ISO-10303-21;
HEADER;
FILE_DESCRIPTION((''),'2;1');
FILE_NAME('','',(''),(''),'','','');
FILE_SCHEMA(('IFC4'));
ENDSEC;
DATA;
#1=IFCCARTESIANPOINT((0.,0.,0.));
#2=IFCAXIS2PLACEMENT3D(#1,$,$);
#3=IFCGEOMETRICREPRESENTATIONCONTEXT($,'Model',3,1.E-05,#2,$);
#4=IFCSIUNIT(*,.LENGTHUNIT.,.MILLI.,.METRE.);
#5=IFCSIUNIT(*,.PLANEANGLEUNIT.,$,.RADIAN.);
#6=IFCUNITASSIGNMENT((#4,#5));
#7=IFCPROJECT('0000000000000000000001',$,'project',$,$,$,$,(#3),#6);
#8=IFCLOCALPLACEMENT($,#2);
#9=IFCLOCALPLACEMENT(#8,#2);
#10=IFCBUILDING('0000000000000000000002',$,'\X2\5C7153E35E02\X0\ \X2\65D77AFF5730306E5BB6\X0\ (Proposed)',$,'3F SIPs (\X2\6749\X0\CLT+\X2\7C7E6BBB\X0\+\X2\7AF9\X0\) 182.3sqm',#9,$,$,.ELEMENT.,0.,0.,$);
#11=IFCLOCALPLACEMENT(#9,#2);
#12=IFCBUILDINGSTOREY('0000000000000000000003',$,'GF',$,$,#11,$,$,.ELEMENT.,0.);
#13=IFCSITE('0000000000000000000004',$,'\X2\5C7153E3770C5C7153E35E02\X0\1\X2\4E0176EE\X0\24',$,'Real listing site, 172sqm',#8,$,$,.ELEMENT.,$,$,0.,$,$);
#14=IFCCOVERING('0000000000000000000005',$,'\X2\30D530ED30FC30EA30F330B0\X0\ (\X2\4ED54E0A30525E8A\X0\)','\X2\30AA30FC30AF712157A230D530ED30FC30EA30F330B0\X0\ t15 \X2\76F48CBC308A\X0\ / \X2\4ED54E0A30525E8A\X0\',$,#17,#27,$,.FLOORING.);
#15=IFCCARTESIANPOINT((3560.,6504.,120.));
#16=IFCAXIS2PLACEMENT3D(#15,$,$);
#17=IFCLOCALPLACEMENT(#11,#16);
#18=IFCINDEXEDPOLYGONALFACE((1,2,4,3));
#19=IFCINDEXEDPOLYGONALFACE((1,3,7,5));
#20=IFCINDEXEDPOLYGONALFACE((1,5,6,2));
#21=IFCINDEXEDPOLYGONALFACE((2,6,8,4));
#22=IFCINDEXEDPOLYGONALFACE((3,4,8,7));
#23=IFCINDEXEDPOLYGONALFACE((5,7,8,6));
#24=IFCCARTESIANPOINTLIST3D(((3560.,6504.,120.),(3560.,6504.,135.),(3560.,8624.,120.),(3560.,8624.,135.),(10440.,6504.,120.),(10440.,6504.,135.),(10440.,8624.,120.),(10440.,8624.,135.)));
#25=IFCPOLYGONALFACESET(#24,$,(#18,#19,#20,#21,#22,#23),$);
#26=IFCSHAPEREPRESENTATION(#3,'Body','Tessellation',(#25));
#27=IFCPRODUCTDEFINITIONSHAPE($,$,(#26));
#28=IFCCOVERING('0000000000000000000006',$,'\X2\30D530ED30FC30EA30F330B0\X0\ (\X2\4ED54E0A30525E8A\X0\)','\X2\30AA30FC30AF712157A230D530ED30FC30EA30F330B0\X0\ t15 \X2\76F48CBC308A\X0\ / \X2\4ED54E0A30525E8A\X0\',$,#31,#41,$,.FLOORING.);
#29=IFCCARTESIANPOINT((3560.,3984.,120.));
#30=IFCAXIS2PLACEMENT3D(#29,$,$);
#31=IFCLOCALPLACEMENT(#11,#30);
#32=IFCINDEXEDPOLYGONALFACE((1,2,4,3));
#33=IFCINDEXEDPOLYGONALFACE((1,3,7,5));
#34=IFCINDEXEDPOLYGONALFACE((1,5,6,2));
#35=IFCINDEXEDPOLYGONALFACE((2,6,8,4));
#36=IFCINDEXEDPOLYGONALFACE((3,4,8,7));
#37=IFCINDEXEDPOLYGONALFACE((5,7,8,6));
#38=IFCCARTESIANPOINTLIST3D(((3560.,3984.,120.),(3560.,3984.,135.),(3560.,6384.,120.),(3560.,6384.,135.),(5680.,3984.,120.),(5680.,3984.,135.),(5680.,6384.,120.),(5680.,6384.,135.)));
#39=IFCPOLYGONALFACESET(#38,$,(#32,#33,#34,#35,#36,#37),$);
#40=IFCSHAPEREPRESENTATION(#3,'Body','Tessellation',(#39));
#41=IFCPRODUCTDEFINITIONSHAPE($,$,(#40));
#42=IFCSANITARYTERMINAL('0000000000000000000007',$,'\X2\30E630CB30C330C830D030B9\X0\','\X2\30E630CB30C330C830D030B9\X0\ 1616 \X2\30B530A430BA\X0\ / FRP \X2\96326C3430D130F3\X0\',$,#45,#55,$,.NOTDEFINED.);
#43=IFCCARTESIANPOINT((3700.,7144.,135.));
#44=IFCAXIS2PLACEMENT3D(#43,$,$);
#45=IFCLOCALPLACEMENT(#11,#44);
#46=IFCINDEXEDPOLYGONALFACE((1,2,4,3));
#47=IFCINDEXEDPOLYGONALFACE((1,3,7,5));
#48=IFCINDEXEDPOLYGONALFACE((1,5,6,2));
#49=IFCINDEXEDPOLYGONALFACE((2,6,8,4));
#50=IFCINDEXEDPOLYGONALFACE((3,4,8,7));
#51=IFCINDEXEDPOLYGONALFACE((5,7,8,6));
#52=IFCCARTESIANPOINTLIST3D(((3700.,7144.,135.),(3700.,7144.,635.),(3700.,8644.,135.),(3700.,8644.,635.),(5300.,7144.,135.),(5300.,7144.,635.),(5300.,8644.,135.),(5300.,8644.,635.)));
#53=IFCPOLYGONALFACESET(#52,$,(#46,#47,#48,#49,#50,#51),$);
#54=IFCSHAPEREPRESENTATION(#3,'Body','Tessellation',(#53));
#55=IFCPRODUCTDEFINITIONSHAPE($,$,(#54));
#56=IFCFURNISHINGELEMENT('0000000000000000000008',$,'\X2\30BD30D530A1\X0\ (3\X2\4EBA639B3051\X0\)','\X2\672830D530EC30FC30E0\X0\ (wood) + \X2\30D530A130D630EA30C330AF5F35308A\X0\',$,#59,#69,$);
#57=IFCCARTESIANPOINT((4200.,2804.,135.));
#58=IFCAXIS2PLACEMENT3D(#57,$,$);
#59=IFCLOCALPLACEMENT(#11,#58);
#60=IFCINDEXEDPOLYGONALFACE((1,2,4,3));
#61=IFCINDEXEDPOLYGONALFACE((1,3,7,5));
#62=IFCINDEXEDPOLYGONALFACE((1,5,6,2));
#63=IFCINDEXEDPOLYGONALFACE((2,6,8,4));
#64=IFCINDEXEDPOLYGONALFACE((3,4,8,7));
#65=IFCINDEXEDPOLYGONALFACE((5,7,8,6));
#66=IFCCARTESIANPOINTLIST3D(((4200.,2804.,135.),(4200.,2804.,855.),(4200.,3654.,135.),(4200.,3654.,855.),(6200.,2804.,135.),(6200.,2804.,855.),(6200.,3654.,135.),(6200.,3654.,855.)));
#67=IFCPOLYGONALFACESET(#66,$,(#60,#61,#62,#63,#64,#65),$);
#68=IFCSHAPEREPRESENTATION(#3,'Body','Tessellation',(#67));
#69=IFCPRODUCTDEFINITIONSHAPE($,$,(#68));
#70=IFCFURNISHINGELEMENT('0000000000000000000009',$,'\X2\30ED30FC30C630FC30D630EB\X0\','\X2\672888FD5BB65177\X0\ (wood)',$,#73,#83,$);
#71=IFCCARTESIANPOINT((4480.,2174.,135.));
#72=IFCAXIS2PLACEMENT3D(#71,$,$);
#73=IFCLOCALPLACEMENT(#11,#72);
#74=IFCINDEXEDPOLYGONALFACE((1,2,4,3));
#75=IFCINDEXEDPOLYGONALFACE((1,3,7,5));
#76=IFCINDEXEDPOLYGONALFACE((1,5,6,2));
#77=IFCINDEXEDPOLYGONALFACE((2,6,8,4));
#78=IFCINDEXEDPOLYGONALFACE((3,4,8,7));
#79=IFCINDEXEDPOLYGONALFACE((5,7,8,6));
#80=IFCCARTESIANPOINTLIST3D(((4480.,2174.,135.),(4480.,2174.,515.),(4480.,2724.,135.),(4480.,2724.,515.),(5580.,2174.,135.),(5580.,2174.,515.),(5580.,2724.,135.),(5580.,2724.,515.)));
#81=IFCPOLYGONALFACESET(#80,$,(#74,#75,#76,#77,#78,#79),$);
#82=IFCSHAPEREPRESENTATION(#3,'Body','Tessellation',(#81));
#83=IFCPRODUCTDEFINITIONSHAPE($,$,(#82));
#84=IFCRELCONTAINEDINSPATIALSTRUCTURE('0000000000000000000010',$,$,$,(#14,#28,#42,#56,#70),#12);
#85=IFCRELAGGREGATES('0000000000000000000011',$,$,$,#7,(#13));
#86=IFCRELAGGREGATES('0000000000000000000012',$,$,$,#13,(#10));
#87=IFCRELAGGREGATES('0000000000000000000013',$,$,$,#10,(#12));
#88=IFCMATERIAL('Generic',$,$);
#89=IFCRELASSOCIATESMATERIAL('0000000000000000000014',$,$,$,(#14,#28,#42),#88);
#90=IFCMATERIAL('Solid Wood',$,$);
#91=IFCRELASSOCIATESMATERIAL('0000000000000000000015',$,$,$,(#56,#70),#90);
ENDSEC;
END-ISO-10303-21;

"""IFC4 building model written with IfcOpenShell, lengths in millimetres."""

from ifc_helpers import new_model, si_unit, frame, frame_2d, origin, place, context, project, spatial, rectangle, extrude, material, element, save


model = new_model("IFC4")

# Units and contexts
model_context = context("Model", 3, precision=1e-05, world=origin())
ifc_project = project(units=[si_unit("LENGTHUNIT", "METRE", prefix="MILLI"), si_unit("PLANEANGLEUNIT", "RADIAN")], contexts=[model_context])

# Site, building, storey
site_placement = place(None, origin())
site = spatial("IfcSite", under=ifc_project, at=site_placement, Name="山口県山口市1丁目24", ObjectType="Real listing site, 172sqm", CompositionType="ELEMENT", RefElevation=0.0)
building_placement = place(site_placement, origin())
building = spatial("IfcBuilding", under=site, at=building_placement, Name="山口市 旗竿地の家 (Proposed)", ObjectType="3F SIPs (杉CLT+籾殻+竹) 182.3sqm", CompositionType="ELEMENT", ElevationOfRefHeight=0.0, ElevationOfTerrain=0.0)
storey_placement = place(building_placement, origin())
storey = spatial("IfcBuildingStorey", under=building, at=storey_placement, Name="GF", CompositionType="ELEMENT", Elevation=0.0)

# Shared definitions
ifc_material_1 = material(Name="Solid Wood")

# Coverings
ifc_material_2 = material(Name="Generic")
covering_1_placement = place(storey_placement, frame((3560.0, 6504.0, 120.0)))
element("IfcCovering", 1, at=covering_1_placement, inside=storey, material=ifc_material_2, Name="フローリング (仕上げ床)", Description="オーク無垢フローリング t15 直貼り / 仕上げ床", PredefinedType="FLOORING", context=model_context, shape_type="SweptSolid", body=[
    extrude(rectangle(XDim=6880.0, YDim=2120.0, at=frame_2d((3440.0, 1060.0))), frame((3560.0, 6504.0, 120.0)), (0.0, 0.0, 1.0), 15.0),
])
covering_2_placement = place(storey_placement, frame((3560.0, 3984.0, 120.0)))
element("IfcCovering", 2, at=covering_2_placement, inside=storey, material=ifc_material_2, Name="フローリング (仕上げ床)", Description="オーク無垢フローリング t15 直貼り / 仕上げ床", PredefinedType="FLOORING", context=model_context, shape_type="SweptSolid", body=[
    extrude(rectangle(XDim=2120.0, YDim=2400.0, at=frame_2d((1060.0, 1200.0))), frame((3560.0, 3984.0, 120.0)), (0.0, 0.0, 1.0), 15.0),
])

# Sanitary terminal
sanitary_terminal_placement = place(storey_placement, frame((3700.0, 7144.0, 135.0)))
element("IfcSanitaryTerminal", 3, at=sanitary_terminal_placement, inside=storey, material=ifc_material_2, Name="ユニットバス", Description="ユニットバス 1616 サイズ / FRP 防水パン", PredefinedType="NOTDEFINED", context=model_context, shape_type="SweptSolid", body=[
    extrude(rectangle(XDim=1600.0, YDim=1500.0, at=frame_2d((800.0, 750.0))), frame((3700.0, 7144.0, 135.0)), (0.0, 0.0, 1.0), 500.0),
])

# Furnishing elements
furnishing_1_placement = place(storey_placement, frame((4200.0, 2804.0, 135.0)))
element("IfcFurnishingElement", 4, at=furnishing_1_placement, inside=storey, material=ifc_material_1, Name="ソファ (3人掛け)", Description="木フレーム (wood) + ファブリック張り", context=model_context, shape_type="SweptSolid", body=[
    extrude(rectangle(XDim=2000.0, YDim=850.0, at=frame_2d((1000.0, 425.0))), frame((4200.0, 2804.0, 135.0)), (0.0, 0.0, 1.0), 720.0),
])
furnishing_2_placement = place(storey_placement, frame((4480.0, 2174.0, 135.0)))
element("IfcFurnishingElement", 5, at=furnishing_2_placement, inside=storey, material=ifc_material_1, Name="ローテーブル", Description="木製家具 (wood)", context=model_context, shape_type="SweptSolid", body=[
    extrude(rectangle(XDim=1100.0, YDim=550.0, at=frame_2d((550.0, 275.0))), frame((4480.0, 2174.0, 135.0)), (0.0, 0.0, 1.0), 380.0),
])

save(model, "model.ifc")
